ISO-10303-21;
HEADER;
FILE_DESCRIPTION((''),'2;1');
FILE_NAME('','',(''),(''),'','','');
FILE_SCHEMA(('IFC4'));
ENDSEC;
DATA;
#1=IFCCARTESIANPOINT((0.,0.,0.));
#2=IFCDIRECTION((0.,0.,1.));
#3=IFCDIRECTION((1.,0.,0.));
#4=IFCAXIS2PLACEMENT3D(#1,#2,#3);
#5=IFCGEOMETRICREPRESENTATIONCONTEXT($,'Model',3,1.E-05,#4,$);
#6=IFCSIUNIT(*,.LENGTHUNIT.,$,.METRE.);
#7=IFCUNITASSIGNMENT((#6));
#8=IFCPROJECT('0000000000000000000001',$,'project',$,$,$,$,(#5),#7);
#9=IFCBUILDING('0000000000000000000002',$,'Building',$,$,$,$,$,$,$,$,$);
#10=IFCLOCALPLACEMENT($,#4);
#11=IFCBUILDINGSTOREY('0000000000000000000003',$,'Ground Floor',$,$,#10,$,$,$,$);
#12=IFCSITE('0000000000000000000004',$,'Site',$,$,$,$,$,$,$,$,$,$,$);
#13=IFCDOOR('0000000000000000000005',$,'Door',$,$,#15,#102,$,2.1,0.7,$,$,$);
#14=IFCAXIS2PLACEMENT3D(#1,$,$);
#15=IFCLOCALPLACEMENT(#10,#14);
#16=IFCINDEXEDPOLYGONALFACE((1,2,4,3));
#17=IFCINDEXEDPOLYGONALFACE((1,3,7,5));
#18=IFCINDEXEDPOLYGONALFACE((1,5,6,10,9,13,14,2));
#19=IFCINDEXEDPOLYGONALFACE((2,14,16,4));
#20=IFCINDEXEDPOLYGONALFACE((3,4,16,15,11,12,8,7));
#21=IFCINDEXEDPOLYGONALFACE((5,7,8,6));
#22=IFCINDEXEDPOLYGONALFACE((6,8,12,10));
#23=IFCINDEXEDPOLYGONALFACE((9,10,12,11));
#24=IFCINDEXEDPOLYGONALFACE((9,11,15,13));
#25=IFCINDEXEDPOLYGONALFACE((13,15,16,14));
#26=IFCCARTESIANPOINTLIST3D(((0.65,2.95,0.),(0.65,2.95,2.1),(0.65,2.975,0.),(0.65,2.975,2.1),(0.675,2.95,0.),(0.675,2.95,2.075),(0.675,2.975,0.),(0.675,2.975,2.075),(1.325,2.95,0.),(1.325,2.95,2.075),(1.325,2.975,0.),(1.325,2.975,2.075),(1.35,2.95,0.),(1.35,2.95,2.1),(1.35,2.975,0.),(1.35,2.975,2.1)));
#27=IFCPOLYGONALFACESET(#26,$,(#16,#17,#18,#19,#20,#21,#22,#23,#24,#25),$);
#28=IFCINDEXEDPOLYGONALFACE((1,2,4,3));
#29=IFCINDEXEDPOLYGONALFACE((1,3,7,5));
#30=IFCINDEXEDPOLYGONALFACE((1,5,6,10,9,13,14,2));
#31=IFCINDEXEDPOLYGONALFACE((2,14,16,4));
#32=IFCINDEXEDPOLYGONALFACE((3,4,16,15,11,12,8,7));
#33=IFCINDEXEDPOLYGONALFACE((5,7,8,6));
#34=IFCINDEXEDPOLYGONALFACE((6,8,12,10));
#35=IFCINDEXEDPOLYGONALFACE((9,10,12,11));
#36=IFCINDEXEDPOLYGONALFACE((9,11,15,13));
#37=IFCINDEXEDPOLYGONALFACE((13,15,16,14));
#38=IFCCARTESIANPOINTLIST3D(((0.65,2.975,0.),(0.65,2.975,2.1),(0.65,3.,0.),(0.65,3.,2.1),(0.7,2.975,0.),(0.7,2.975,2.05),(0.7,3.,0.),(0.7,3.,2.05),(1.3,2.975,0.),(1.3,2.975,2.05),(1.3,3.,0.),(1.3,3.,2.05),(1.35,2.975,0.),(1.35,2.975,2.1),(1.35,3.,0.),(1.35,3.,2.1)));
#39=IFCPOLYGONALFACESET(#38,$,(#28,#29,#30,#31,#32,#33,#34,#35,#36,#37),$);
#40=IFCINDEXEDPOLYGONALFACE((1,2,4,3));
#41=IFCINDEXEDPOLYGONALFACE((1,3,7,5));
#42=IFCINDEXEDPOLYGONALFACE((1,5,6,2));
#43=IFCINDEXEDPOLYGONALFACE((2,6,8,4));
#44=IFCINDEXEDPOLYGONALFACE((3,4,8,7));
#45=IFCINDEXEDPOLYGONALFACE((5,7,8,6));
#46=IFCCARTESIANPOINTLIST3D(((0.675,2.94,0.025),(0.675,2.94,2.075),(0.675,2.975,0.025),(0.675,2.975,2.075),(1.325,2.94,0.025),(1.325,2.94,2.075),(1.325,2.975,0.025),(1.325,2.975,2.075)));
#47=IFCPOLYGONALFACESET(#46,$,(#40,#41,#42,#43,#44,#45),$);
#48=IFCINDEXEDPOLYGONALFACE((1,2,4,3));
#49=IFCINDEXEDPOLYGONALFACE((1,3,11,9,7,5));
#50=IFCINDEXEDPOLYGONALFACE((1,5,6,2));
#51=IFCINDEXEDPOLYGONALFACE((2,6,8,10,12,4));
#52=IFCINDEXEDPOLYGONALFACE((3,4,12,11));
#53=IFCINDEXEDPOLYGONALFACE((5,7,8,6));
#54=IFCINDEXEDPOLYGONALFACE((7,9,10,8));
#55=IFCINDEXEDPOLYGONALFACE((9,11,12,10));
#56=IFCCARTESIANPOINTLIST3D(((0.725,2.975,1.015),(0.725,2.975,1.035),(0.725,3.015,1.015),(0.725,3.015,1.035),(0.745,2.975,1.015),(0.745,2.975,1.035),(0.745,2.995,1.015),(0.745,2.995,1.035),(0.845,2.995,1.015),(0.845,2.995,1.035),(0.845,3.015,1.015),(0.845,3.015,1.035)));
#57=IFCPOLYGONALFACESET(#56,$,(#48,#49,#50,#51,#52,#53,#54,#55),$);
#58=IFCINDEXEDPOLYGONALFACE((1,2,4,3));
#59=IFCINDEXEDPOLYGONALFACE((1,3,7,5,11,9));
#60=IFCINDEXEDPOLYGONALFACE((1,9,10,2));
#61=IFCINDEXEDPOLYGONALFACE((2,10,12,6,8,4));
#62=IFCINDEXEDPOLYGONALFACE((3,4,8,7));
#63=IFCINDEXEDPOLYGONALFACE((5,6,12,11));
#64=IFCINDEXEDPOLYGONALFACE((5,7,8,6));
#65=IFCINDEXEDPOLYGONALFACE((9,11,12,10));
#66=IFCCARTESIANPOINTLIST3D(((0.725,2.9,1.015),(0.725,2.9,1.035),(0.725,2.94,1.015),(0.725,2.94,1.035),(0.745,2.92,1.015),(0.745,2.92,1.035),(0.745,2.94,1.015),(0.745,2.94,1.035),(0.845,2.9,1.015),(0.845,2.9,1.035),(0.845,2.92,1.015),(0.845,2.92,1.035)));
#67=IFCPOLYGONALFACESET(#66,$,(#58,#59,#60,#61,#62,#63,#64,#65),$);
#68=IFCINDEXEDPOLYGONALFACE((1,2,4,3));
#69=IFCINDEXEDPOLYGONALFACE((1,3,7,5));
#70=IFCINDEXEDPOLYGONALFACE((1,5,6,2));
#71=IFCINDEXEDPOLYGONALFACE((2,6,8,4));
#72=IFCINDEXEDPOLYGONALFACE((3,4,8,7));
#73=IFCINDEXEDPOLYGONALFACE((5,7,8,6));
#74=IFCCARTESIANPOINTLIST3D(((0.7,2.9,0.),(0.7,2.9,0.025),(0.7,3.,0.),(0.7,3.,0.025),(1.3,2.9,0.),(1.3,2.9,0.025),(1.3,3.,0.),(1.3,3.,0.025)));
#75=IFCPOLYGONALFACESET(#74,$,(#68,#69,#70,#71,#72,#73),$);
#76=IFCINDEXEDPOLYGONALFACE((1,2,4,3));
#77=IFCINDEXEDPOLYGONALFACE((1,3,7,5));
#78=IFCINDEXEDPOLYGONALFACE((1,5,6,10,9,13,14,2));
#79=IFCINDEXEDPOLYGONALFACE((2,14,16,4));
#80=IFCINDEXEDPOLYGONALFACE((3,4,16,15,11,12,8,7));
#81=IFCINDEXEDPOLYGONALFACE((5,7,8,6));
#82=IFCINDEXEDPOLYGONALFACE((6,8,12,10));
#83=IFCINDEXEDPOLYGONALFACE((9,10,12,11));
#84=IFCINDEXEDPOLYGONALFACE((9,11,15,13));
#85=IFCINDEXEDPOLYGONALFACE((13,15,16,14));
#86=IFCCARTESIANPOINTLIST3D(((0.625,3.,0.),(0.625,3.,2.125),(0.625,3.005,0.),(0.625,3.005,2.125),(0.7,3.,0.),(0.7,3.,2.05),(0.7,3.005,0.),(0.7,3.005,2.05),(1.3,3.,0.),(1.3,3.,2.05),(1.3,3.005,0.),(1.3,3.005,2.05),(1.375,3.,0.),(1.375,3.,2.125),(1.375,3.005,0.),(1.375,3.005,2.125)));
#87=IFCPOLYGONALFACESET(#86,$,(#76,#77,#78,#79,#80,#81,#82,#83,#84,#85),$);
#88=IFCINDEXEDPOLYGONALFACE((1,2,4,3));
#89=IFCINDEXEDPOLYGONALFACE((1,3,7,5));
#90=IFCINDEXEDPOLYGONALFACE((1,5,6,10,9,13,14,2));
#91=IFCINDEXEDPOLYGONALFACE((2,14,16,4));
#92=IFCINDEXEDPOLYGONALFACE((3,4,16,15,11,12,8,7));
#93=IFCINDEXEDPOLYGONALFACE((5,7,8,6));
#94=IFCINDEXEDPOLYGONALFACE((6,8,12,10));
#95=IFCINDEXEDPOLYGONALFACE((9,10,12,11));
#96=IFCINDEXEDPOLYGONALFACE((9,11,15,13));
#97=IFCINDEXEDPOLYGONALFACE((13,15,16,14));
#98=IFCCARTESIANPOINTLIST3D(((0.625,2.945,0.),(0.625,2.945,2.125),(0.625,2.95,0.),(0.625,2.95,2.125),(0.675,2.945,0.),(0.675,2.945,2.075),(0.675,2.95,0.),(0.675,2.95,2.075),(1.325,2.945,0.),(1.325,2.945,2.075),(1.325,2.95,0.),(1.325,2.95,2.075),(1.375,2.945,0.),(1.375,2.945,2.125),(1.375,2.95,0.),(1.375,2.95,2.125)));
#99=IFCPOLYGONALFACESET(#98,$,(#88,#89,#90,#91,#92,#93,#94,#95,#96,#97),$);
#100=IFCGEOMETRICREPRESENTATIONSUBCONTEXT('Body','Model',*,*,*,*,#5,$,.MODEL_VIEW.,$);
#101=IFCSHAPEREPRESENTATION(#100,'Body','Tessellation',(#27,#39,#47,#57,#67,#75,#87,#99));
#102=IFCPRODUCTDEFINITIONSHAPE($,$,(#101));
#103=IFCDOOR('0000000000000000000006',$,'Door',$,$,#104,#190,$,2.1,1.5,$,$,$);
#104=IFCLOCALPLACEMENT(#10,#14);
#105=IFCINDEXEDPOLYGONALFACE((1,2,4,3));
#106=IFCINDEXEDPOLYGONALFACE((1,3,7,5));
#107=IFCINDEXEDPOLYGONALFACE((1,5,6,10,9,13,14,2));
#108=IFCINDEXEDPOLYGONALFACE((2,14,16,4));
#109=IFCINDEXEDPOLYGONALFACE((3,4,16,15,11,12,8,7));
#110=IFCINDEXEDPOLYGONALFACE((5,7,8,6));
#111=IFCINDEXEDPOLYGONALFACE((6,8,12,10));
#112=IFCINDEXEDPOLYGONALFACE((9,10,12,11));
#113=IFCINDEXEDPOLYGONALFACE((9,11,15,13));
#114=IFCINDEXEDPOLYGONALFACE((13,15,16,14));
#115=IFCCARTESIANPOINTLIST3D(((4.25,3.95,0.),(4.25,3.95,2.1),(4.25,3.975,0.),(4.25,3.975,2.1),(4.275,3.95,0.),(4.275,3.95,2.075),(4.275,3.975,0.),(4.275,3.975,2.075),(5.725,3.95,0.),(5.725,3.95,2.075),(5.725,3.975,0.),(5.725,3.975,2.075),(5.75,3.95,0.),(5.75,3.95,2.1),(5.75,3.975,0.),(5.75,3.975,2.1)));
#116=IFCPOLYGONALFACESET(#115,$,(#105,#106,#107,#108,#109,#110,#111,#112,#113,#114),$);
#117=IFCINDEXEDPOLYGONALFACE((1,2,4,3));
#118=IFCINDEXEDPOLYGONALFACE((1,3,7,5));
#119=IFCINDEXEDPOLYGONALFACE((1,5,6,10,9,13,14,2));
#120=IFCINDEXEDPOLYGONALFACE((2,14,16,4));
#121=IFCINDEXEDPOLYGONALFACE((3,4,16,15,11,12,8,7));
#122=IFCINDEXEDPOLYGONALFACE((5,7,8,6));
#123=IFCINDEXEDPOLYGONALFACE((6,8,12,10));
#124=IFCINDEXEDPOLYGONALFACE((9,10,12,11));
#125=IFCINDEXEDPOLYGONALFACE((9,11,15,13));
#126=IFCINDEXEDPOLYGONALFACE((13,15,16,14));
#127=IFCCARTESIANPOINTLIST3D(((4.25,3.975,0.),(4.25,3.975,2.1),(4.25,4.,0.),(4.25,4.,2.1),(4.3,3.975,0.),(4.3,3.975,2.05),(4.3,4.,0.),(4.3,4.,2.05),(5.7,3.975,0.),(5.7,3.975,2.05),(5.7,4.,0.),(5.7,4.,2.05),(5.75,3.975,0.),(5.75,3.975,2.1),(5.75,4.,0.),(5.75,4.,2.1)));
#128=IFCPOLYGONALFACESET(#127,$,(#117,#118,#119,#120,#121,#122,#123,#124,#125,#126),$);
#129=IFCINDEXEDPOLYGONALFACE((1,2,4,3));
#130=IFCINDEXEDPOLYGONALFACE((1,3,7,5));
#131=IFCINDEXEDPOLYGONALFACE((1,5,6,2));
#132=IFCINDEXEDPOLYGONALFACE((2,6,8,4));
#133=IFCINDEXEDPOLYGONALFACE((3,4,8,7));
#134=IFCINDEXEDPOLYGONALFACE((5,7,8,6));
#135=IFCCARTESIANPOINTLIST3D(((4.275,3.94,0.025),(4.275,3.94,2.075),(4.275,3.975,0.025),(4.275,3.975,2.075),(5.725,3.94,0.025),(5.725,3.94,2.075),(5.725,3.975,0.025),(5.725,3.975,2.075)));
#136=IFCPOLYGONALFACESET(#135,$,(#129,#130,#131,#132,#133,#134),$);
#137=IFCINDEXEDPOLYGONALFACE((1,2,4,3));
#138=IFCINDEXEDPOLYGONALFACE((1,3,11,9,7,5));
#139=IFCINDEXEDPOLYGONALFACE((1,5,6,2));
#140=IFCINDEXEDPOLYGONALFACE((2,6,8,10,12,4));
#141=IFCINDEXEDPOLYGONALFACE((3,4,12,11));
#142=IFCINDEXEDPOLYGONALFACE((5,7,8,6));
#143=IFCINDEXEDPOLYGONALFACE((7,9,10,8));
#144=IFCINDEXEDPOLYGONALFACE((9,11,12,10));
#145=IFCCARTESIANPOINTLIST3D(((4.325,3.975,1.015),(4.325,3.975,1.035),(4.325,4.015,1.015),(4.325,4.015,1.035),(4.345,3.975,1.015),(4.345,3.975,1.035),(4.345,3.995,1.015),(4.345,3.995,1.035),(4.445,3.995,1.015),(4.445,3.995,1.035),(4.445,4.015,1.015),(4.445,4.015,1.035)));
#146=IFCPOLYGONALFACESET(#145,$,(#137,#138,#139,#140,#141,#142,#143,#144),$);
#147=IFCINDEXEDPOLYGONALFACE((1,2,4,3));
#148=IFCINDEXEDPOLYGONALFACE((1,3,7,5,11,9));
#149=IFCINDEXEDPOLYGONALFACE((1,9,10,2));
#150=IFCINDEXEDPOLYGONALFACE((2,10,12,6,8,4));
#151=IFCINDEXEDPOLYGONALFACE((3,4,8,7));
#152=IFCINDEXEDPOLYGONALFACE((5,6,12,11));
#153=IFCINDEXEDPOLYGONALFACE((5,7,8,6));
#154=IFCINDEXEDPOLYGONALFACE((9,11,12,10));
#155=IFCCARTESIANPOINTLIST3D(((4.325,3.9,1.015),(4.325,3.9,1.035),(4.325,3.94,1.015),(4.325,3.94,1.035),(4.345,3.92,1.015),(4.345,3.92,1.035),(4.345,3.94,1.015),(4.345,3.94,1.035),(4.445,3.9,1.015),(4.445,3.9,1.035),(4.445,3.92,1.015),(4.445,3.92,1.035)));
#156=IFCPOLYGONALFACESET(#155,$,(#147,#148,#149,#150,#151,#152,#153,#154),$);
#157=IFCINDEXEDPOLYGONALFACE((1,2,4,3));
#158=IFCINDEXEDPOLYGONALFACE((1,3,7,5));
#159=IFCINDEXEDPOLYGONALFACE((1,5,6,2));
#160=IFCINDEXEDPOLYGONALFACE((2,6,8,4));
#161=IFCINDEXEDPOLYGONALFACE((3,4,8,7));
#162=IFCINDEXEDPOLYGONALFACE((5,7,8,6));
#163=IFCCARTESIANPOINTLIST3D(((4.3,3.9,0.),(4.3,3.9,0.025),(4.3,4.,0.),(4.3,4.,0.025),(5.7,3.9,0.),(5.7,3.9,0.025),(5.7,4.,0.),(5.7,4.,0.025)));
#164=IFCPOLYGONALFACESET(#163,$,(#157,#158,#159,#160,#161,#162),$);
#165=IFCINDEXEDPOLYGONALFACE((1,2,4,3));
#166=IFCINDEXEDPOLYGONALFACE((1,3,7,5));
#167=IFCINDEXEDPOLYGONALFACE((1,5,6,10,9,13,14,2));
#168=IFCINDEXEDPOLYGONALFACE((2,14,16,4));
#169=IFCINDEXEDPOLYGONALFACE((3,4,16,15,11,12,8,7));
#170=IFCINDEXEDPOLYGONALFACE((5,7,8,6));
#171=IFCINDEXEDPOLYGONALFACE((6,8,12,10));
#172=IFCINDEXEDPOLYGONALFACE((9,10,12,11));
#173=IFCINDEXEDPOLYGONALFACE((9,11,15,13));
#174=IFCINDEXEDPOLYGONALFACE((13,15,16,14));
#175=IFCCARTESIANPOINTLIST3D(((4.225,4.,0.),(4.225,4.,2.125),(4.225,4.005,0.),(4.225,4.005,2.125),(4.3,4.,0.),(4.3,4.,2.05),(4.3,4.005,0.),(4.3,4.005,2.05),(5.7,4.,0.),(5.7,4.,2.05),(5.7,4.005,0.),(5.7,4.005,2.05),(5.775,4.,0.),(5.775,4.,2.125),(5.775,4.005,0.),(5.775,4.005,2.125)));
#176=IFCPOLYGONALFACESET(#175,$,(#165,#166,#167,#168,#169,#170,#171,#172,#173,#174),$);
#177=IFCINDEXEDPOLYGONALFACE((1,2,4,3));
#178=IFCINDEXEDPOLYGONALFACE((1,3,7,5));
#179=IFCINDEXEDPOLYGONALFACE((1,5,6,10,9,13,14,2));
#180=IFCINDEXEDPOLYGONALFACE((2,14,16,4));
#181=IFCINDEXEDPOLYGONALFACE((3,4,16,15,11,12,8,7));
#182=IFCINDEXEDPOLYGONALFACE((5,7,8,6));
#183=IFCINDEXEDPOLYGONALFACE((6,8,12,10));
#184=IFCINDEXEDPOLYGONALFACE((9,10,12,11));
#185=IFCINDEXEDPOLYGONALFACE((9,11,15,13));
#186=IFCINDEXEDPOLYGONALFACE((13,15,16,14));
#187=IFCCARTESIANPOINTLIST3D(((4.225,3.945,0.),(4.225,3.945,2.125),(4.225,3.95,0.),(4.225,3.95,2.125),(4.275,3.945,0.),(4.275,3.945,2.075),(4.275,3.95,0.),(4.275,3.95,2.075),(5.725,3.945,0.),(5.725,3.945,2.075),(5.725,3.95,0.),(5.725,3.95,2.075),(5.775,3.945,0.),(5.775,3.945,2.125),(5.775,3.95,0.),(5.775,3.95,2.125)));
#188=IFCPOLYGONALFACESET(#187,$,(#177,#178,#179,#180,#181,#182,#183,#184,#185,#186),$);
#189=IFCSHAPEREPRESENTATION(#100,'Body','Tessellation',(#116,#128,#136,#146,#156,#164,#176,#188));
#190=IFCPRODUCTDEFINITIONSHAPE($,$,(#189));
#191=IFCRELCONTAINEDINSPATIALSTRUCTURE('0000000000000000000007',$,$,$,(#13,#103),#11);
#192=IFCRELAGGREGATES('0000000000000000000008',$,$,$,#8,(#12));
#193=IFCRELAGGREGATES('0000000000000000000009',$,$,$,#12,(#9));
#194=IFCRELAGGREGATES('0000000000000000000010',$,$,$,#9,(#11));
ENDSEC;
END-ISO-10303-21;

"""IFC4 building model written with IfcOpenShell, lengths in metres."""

from ifc_helpers import new_model, si_unit, frame, origin_with_axes, place, context, subcontext, project, spatial, line, indexed_curve, outline, extrude, element, save


model = new_model("IFC4")

# Units and contexts
model_context = context("Model", 3, precision=1e-05, world=origin_with_axes())
body_context = subcontext(model_context, "Body", "Model", "MODEL_VIEW")
ifc_project = project(units=[si_unit("LENGTHUNIT", "METRE")], contexts=[model_context])

# Site, building, storey
site = spatial("IfcSite", under=ifc_project, Name="Site")
building = spatial("IfcBuilding", under=site, Name="Building")
storey_placement = place(None, origin_with_axes())
storey = spatial("IfcBuildingStorey", under=building, at=storey_placement, Name="Ground Floor")

# Doors
door_1_placement = place(storey_placement, frame((1.35, 3.0, 0.0), z_axis=(0.0, 0.0, 1.0), x_axis=(-1.0, 0.0, 0.0)))
element("IfcDoor", 1, at=door_1_placement, inside=storey, Name="Door", OverallHeight=2.1, OverallWidth=0.7, context=body_context, shape_type="SweptSolid", body=[
    extrude(outline(indexed_curve([(0.0, 0.0), (0.0, 2.1), (0.7, 2.1), (0.7, 0.0), (0.675, 0.0), (0.675, 2.075), (0.025, 2.075), (0.025, 0.0)], segments=[line(1, 2, 3, 4, 5, 6, 7, 8, 1)])), frame((0.0, 0.025, 0.0), z_axis=(0.0, -1.0, 0.0), x_axis=(1.0, 0.0, 0.0)), (0.0, 0.0, -1.0), 0.025),
    extrude(outline(indexed_curve([(0.0, 0.0), (0.0, 2.1), (0.7, 2.1), (0.7, 0.0), (0.65, 0.0), (0.65, 2.05), (0.05, 2.05), (0.05, 0.0)], segments=[line(1, 2, 3, 4, 5, 6, 7, 8, 1)])), frame((0.0, 0.0, 0.0), z_axis=(0.0, -1.0, 0.0), x_axis=(1.0, 0.0, 0.0)), (0.0, 0.0, -1.0), 0.025),
    extrude(outline(indexed_curve([(0.0, 0.0), (0.65, 0.0), (0.65, 0.035), (0.0, 0.035)], segments=[line(1, 2, 3, 4, 1)])), frame((0.025, 0.025, 0.025), z_axis=(0.0, 0.0, 1.0), x_axis=(1.0, 0.0, 0.0)), (0.0, 0.0, 1.0), 2.05),
    extrude(outline(indexed_curve([(0.0, 0.0), (0.0, -0.04), (-0.12, -0.04), (-0.12, -0.02), (-0.02, -0.02), (-0.02, 0.0)], segments=[line(1, 2, 3, 4, 5, 6, 1)])), frame((0.625, 0.025, 1.015), z_axis=(0.0, 0.0, 1.0), x_axis=(1.0, 0.0, 0.0)), (0.0, 0.0, 1.0), 0.02),
    extrude(outline(indexed_curve([(0.0, 0.0), (0.0, 0.04), (-0.12, 0.04), (-0.12, 0.02), (-0.02, 0.02), (-0.02, 0.0)], segments=[line(1, 2, 3, 4, 5, 6, 1)])), frame((0.625, 0.06, 1.015), z_axis=(0.0, 0.0, 1.0), x_axis=(1.0, 0.0, 0.0)), (0.0, 0.0, 1.0), 0.02),
    extrude(outline(indexed_curve([(0.0, 0.0), (0.6, 0.0), (0.6, 0.1), (0.0, 0.1)], segments=[line(1, 2, 3, 4, 1)])), frame((0.05, 0.0, 0.0), z_axis=(0.0, 0.0, 1.0), x_axis=(1.0, 0.0, 0.0)), (0.0, 0.0, 1.0), 0.025),
    extrude(outline(indexed_curve([(0.0, 0.0), (0.0, 2.125), (0.75, 2.125), (0.75, 0.0), (0.675, 0.0), (0.675, 2.05), (0.075, 2.05), (0.075, 0.0)], segments=[line(1, 2, 3, 4, 5, 6, 7, 8, 1)])), frame((-0.025, -0.005, 0.0), z_axis=(0.0, -1.0, 0.0), x_axis=(1.0, 0.0, 0.0)), (0.0, 0.0, -1.0), 0.005),
    extrude(outline(indexed_curve([(0.0, 0.0), (0.0, 2.125), (0.75, 2.125), (0.75, 0.0), (0.7, 0.0), (0.7, 2.075), (0.05, 2.075), (0.05, 0.0)], segments=[line(1, 2, 3, 4, 5, 6, 7, 8, 1)])), frame((-0.025, 0.05, 0.0), z_axis=(0.0, -1.0, 0.0), x_axis=(1.0, 0.0, 0.0)), (0.0, 0.0, -1.0), 0.005),
])
door_2_placement = place(storey_placement, frame((5.75, 4.0, 0.0), z_axis=(0.0, 0.0, 1.0), x_axis=(-1.0, 0.0, 0.0)))
element("IfcDoor", 2, at=door_2_placement, inside=storey, Name="Door", OverallHeight=2.1, OverallWidth=1.5, context=body_context, shape_type="SweptSolid", body=[
    extrude(outline(indexed_curve([(0.0, 0.0), (0.0, 2.1), (1.5, 2.1), (1.5, 0.0), (1.475, 0.0), (1.475, 2.075), (0.025, 2.075), (0.025, 0.0)], segments=[line(1, 2, 3, 4, 5, 6, 7, 8, 1)])), frame((0.0, 0.025, 0.0), z_axis=(0.0, -1.0, 0.0), x_axis=(1.0, 0.0, 0.0)), (0.0, 0.0, -1.0), 0.025),
    extrude(outline(indexed_curve([(0.0, 0.0), (0.0, 2.1), (1.5, 2.1), (1.5, 0.0), (1.45, 0.0), (1.45, 2.05), (0.05, 2.05), (0.05, 0.0)], segments=[line(1, 2, 3, 4, 5, 6, 7, 8, 1)])), frame((0.0, 0.0, 0.0), z_axis=(0.0, -1.0, 0.0), x_axis=(1.0, 0.0, 0.0)), (0.0, 0.0, -1.0), 0.025),
    extrude(outline(indexed_curve([(0.0, 0.0), (1.45, 0.0), (1.45, 0.035), (0.0, 0.035)], segments=[line(1, 2, 3, 4, 1)])), frame((0.025, 0.025, 0.025), z_axis=(0.0, 0.0, 1.0), x_axis=(1.0, 0.0, 0.0)), (0.0, 0.0, 1.0), 2.05),
    extrude(outline(indexed_curve([(0.0, 0.0), (0.0, -0.04), (-0.12, -0.04), (-0.12, -0.02), (-0.02, -0.02), (-0.02, 0.0)], segments=[line(1, 2, 3, 4, 5, 6, 1)])), frame((1.425, 0.025, 1.015), z_axis=(0.0, 0.0, 1.0), x_axis=(1.0, 0.0, 0.0)), (0.0, 0.0, 1.0), 0.02),
    extrude(outline(indexed_curve([(0.0, 0.0), (0.0, 0.04), (-0.12, 0.04), (-0.12, 0.02), (-0.02, 0.02), (-0.02, 0.0)], segments=[line(1, 2, 3, 4, 5, 6, 1)])), frame((1.425, 0.06, 1.015), z_axis=(0.0, 0.0, 1.0), x_axis=(1.0, 0.0, 0.0)), (0.0, 0.0, 1.0), 0.02),
    extrude(outline(indexed_curve([(0.0, 0.0), (1.4, 0.0), (1.4, 0.1), (0.0, 0.1)], segments=[line(1, 2, 3, 4, 1)])), frame((0.05, 0.0, 0.0), z_axis=(0.0, 0.0, 1.0), x_axis=(1.0, 0.0, 0.0)), (0.0, 0.0, 1.0), 0.025),
    extrude(outline(indexed_curve([(0.0, 0.0), (0.0, 2.125), (1.55, 2.125), (1.55, 0.0), (1.475, 0.0), (1.475, 2.05), (0.075, 2.05), (0.075, 0.0)], segments=[line(1, 2, 3, 4, 5, 6, 7, 8, 1)])), frame((-0.025, -0.005, 0.0), z_axis=(0.0, -1.0, 0.0), x_axis=(1.0, 0.0, 0.0)), (0.0, 0.0, -1.0), 0.005),
    extrude(outline(indexed_curve([(0.0, 0.0), (0.0, 2.125), (1.55, 2.125), (1.55, 0.0), (1.5, 0.0), (1.5, 2.075), (0.05, 2.075), (0.05, 0.0)], segments=[line(1, 2, 3, 4, 5, 6, 7, 8, 1)])), frame((-0.025, 0.05, 0.0), z_axis=(0.0, -1.0, 0.0), x_axis=(1.0, 0.0, 0.0)), (0.0, 0.0, -1.0), 0.005),
])

save(model, "model.ifc")
